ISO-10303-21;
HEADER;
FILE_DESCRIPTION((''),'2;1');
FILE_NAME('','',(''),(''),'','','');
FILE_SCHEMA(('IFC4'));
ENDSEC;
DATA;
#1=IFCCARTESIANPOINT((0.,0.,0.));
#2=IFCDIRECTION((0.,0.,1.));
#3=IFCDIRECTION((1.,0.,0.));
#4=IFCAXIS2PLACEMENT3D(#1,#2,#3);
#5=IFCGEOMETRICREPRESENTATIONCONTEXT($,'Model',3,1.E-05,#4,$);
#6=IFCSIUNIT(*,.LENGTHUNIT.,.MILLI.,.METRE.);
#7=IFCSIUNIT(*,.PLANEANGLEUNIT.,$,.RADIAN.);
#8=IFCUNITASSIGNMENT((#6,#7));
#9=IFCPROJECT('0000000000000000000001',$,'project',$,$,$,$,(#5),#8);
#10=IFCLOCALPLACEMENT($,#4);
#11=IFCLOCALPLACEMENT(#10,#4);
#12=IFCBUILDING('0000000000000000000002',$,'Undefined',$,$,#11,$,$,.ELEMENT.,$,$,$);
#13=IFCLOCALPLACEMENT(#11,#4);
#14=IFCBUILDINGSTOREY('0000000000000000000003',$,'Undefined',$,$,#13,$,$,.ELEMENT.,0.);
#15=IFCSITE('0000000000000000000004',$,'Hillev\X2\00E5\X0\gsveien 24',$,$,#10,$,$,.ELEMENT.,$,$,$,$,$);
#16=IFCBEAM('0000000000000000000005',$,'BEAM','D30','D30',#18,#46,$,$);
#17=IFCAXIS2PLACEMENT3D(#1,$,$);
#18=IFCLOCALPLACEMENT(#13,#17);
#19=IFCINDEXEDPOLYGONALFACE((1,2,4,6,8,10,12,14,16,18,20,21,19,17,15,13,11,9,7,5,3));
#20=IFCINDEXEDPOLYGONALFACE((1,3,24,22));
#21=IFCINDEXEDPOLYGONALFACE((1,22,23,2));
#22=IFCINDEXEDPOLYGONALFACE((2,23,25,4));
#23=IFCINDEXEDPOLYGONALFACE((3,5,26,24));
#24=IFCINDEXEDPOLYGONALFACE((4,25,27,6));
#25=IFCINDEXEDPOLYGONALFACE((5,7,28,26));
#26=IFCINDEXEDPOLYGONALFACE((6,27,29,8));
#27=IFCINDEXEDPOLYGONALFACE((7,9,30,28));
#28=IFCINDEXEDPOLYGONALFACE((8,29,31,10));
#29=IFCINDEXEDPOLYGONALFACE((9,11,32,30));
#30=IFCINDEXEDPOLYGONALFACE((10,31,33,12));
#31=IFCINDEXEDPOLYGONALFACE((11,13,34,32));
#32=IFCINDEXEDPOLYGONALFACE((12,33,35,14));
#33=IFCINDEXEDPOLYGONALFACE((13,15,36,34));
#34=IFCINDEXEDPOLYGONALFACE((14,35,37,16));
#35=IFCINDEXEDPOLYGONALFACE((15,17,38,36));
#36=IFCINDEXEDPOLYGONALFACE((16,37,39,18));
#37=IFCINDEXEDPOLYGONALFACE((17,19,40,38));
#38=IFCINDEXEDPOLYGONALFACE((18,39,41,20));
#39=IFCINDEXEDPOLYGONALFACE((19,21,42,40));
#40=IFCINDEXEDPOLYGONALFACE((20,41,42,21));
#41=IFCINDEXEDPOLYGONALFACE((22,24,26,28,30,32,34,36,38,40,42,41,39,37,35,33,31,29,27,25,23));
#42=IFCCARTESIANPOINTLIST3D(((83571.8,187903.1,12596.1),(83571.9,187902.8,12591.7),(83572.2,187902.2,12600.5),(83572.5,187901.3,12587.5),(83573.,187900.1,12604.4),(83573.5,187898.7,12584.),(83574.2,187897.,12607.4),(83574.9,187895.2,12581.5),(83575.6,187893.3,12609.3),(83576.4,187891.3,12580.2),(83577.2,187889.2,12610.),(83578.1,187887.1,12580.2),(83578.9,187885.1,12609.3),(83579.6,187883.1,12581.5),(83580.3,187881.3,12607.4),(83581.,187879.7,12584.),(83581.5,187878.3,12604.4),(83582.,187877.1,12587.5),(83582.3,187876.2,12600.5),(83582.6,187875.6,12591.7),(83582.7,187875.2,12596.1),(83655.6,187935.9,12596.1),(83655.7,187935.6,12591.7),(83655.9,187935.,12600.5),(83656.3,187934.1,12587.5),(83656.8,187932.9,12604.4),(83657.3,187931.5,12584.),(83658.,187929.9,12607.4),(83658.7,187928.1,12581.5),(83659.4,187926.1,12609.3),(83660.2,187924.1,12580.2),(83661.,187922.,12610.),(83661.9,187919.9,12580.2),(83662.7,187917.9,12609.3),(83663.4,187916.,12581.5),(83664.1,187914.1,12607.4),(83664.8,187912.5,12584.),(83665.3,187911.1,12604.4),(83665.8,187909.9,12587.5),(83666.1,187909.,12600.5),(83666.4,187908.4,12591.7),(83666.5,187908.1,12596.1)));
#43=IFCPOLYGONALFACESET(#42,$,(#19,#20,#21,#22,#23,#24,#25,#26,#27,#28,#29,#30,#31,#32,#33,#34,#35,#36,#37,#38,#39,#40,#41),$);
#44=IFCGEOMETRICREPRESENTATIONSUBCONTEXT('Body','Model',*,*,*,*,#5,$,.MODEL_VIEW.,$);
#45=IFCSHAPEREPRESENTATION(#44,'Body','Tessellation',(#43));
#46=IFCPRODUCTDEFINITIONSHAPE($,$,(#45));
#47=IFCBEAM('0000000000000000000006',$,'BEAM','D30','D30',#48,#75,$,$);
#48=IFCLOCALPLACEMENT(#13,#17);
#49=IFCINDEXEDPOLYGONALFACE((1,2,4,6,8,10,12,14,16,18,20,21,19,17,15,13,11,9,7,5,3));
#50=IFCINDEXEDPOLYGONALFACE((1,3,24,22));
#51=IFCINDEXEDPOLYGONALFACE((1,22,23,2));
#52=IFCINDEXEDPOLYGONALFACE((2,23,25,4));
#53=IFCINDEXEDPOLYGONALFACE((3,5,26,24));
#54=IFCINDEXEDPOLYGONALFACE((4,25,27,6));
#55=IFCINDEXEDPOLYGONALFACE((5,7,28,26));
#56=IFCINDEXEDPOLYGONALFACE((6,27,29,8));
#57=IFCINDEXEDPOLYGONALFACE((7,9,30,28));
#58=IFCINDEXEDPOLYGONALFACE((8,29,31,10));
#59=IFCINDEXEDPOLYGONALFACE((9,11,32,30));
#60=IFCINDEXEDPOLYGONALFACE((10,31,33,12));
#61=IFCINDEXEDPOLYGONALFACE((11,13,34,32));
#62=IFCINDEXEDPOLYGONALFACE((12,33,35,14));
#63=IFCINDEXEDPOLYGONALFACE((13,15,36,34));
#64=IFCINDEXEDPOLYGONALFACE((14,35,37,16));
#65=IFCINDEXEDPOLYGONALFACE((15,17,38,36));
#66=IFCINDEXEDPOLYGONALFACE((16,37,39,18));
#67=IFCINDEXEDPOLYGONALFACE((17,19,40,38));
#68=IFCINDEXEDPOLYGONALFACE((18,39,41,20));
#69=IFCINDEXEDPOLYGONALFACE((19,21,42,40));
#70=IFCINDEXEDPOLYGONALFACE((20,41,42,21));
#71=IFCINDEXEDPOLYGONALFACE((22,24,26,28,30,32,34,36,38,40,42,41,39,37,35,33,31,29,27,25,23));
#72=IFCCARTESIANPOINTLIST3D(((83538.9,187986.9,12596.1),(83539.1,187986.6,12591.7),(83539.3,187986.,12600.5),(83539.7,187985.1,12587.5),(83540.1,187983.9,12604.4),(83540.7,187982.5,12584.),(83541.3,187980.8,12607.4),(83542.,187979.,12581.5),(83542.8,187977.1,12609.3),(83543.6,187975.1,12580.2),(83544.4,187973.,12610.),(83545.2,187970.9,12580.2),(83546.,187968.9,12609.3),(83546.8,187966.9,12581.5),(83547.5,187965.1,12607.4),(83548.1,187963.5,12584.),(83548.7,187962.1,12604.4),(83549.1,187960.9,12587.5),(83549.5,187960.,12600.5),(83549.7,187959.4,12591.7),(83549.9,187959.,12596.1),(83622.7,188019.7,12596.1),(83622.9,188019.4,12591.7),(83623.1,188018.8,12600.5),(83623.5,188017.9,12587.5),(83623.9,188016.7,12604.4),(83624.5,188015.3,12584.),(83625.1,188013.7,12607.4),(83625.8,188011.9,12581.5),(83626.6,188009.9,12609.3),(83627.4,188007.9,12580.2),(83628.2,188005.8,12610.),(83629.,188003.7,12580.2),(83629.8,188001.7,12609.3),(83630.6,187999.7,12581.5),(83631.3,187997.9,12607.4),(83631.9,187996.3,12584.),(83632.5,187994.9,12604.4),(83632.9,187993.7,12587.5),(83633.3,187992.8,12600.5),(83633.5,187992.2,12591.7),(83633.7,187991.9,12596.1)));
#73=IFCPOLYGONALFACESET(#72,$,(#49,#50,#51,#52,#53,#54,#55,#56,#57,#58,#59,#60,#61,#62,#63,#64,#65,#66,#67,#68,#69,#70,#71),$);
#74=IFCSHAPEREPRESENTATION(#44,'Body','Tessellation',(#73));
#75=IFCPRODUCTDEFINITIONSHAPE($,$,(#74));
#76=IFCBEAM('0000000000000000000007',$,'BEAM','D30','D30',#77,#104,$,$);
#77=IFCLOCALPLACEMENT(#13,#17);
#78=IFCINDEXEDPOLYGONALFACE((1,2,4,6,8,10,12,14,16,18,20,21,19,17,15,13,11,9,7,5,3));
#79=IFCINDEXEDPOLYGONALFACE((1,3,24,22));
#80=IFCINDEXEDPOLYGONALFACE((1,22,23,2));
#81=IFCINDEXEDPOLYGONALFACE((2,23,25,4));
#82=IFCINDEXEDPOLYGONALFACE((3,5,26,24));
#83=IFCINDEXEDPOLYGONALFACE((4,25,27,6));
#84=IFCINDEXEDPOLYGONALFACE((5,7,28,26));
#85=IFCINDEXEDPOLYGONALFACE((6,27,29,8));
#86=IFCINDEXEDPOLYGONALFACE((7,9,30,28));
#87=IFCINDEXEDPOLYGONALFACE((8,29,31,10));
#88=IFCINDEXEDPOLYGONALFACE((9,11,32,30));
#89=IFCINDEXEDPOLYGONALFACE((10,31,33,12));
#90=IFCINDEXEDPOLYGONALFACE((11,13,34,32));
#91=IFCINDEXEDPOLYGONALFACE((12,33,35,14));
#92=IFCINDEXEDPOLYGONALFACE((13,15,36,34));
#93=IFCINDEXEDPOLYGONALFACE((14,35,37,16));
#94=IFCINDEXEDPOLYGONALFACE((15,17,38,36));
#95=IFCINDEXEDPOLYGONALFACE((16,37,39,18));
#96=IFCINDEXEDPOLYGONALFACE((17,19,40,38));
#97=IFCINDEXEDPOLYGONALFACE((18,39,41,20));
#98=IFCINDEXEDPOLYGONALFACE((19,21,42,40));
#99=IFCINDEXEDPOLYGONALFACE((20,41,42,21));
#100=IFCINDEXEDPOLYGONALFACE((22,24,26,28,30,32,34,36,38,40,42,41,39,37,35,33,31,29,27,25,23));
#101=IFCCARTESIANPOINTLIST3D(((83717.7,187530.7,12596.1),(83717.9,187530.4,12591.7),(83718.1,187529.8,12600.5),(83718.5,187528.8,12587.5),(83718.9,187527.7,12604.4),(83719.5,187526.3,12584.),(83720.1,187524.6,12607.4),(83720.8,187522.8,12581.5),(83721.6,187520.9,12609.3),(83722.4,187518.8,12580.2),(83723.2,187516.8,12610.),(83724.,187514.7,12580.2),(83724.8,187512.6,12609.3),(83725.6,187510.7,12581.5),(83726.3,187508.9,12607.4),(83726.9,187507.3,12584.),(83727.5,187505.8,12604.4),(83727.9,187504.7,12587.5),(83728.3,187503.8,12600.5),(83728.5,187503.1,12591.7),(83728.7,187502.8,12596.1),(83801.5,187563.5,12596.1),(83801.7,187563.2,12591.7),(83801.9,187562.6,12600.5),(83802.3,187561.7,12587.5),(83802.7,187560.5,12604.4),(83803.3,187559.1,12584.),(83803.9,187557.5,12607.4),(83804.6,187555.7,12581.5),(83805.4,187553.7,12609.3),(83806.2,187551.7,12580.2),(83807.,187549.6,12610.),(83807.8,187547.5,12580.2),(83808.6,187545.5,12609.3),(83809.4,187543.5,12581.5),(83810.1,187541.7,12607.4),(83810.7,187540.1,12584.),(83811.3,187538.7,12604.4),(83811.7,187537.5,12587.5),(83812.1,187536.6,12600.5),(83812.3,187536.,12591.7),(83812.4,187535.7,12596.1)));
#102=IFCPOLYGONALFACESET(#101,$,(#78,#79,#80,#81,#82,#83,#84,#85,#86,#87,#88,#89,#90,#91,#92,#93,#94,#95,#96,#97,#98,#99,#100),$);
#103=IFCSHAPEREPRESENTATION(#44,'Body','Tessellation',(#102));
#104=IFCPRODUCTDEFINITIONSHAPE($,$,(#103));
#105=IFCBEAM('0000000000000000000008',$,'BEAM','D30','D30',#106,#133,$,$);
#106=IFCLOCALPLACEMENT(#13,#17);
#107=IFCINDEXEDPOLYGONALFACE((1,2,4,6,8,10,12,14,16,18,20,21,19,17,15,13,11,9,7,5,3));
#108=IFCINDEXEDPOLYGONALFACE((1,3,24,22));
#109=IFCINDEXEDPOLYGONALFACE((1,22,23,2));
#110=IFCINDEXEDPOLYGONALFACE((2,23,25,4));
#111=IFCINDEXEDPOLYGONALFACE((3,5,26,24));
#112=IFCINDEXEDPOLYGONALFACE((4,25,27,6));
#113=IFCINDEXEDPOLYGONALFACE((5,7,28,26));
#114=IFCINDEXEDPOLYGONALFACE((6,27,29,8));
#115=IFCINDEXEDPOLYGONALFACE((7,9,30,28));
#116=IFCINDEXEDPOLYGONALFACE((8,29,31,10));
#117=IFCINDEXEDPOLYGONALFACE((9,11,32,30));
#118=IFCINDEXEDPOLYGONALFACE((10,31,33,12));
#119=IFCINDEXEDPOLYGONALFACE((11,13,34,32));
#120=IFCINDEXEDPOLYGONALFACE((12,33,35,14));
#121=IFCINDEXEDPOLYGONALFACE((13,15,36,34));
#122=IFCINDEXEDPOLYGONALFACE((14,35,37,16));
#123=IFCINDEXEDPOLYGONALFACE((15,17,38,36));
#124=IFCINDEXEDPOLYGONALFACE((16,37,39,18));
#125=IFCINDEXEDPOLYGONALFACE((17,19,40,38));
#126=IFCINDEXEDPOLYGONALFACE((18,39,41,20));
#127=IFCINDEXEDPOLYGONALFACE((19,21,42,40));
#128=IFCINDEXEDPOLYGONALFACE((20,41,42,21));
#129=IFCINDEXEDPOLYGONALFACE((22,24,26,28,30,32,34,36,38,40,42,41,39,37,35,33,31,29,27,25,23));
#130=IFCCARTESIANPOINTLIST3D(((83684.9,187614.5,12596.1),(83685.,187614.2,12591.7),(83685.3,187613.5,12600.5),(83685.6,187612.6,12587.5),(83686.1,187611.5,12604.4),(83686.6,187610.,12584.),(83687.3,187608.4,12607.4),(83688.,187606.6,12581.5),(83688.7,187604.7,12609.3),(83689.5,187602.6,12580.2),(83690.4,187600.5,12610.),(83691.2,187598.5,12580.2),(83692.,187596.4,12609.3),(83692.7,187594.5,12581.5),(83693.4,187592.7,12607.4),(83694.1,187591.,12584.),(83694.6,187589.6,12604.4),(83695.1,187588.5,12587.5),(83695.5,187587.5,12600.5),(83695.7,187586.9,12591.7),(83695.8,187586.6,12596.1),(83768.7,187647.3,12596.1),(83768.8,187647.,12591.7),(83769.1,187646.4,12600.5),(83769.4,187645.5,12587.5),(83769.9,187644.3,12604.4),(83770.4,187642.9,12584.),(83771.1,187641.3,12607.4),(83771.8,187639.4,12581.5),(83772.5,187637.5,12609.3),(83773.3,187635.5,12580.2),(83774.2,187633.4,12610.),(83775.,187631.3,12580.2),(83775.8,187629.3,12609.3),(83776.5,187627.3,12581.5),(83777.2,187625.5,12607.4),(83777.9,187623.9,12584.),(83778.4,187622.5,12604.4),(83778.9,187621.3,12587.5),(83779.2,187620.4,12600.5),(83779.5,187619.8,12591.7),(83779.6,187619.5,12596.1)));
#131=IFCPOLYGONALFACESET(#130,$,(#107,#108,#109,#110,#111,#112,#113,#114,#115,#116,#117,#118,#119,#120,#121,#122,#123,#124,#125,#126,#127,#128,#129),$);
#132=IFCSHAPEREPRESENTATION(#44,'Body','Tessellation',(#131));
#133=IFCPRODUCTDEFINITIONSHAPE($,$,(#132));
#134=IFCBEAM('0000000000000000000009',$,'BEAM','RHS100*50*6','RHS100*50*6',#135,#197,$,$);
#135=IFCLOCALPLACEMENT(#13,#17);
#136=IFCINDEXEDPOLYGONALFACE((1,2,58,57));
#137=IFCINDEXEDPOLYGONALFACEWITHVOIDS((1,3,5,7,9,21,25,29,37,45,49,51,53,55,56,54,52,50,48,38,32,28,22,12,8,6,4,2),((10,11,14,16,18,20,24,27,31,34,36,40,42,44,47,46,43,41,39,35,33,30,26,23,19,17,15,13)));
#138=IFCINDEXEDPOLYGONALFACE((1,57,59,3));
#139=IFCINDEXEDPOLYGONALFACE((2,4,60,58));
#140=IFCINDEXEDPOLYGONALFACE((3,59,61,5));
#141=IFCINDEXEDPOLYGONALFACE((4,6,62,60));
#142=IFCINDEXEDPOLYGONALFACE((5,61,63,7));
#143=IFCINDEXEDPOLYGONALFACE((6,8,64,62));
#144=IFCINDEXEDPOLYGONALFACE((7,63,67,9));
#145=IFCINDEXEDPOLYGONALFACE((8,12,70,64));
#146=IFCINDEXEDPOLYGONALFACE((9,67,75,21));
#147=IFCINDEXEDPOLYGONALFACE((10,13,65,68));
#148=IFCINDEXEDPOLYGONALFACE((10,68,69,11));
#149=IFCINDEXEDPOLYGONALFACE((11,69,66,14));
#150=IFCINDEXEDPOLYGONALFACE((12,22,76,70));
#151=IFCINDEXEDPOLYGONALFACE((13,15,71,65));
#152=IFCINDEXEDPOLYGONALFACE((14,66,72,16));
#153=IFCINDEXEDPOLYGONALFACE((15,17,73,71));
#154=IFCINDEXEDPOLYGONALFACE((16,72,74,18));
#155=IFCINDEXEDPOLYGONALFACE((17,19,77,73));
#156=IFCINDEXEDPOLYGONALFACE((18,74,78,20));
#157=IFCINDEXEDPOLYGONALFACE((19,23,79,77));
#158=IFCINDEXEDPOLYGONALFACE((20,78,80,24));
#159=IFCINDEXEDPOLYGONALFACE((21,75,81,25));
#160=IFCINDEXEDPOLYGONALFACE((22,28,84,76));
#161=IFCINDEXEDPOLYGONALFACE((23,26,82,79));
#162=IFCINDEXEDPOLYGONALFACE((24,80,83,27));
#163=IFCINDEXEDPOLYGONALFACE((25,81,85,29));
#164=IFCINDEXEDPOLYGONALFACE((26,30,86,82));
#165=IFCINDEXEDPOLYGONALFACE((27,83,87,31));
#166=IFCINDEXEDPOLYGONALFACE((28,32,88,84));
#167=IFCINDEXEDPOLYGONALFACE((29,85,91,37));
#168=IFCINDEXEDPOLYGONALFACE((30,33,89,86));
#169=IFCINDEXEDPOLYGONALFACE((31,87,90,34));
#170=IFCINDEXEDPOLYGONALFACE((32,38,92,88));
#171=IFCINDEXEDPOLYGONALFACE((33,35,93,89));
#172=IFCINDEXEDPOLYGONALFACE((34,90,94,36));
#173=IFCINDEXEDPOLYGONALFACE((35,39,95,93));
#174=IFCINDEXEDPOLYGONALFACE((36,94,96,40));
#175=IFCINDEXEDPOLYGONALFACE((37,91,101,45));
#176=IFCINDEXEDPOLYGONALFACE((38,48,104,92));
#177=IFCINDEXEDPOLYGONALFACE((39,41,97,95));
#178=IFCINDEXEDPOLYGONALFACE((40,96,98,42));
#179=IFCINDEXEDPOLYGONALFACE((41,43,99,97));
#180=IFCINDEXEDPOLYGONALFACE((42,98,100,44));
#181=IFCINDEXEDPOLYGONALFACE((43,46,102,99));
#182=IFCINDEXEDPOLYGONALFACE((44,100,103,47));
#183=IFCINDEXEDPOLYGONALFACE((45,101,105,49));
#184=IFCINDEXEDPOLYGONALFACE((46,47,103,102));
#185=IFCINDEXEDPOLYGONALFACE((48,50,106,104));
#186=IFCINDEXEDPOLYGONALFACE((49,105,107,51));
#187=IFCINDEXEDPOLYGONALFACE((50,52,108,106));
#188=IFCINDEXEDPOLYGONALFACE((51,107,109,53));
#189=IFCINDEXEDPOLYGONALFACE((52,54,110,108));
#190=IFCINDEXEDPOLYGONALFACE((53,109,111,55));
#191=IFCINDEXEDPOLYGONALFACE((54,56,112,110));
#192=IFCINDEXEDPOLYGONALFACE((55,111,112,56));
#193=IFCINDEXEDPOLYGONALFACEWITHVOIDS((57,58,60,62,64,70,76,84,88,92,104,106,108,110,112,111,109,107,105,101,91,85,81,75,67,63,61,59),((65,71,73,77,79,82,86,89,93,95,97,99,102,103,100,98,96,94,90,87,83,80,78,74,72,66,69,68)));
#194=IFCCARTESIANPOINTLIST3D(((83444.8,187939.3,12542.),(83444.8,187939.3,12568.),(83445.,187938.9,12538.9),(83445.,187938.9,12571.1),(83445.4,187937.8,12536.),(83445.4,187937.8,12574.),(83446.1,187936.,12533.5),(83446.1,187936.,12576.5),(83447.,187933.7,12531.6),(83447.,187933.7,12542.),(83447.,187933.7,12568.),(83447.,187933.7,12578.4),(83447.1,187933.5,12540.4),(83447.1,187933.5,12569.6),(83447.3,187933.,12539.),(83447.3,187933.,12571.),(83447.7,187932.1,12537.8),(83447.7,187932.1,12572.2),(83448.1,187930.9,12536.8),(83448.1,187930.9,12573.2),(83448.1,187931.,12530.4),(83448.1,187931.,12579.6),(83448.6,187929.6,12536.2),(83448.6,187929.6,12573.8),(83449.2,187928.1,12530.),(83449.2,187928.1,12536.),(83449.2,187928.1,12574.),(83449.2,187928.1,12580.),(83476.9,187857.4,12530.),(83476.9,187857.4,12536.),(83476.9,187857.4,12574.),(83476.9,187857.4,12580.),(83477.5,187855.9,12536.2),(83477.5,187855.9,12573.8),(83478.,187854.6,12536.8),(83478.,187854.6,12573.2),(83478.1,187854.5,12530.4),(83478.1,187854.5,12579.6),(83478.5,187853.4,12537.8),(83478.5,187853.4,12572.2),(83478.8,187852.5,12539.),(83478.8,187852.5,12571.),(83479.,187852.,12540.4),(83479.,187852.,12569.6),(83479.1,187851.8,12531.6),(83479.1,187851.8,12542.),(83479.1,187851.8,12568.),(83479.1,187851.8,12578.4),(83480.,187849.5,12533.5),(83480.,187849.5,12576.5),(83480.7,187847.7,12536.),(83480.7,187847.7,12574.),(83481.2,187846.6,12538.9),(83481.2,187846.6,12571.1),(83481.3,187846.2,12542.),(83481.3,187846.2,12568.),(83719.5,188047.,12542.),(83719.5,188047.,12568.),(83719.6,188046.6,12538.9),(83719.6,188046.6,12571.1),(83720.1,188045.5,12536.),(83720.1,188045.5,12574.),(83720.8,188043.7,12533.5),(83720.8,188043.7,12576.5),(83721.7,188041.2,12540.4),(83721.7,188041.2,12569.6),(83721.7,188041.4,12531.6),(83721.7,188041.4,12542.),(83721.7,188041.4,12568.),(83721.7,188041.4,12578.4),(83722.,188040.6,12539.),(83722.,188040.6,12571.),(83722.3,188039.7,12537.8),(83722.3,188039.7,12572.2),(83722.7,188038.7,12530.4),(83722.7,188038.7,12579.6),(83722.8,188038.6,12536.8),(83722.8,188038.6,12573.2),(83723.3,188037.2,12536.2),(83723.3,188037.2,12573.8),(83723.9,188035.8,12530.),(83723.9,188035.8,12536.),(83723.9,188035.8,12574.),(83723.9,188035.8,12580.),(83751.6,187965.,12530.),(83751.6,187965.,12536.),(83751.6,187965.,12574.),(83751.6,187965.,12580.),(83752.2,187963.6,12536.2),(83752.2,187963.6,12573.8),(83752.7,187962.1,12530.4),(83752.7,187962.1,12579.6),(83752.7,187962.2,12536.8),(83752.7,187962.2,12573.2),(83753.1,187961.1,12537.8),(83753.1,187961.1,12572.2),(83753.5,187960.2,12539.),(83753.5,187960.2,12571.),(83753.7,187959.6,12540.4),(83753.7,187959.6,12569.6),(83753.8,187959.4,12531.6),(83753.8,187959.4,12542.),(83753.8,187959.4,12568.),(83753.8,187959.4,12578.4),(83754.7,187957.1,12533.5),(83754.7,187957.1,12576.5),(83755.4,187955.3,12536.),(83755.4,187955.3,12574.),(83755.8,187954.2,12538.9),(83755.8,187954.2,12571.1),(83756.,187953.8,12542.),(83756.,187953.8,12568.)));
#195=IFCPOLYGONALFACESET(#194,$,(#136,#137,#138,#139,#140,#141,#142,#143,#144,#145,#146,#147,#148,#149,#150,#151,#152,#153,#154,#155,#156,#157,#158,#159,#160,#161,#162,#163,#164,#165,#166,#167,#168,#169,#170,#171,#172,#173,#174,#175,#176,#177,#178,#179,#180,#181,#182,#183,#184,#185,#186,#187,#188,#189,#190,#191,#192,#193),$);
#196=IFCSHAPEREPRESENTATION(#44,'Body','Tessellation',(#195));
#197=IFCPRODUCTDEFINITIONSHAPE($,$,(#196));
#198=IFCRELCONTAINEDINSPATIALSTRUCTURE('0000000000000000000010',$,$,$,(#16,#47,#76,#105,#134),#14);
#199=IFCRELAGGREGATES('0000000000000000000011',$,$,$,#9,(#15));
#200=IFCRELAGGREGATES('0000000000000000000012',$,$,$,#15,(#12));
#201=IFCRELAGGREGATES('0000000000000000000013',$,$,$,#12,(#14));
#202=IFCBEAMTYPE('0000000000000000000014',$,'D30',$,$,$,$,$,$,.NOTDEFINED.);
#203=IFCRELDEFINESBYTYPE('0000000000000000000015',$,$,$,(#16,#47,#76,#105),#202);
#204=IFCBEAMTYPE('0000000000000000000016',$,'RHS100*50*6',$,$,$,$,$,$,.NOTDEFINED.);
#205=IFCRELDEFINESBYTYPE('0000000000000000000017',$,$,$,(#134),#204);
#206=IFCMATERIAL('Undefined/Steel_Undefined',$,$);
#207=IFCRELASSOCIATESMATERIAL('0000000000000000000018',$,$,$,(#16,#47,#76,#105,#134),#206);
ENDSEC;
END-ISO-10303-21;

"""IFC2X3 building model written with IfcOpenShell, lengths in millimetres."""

from ifc_helpers import new_model, si_unit, frame, frame_2d, origin_with_axes, place, context, subcontext, project, spatial, hollow_rectangle, circle, extrude, material, type_object, element, save


model = new_model("IFC2X3")

# Units and contexts
model_context = context("Model", 3, precision=1e-05, world=origin_with_axes())
body_context = subcontext(model_context, "Body", "Model", "MODEL_VIEW")
ifc_project = project(units=[si_unit("LENGTHUNIT", "METRE", prefix="MILLI"), si_unit("PLANEANGLEUNIT", "RADIAN")], contexts=[model_context])

# Site, building, storey
site_placement = place(None, origin_with_axes())
site = spatial("IfcSite", under=ifc_project, at=site_placement, Name="Hillevågsveien 24", CompositionType="ELEMENT")
building_placement = place(site_placement, origin_with_axes())
building = spatial("IfcBuilding", under=site, at=building_placement, Name="Undefined", CompositionType="ELEMENT")
storey_placement = place(building_placement, origin_with_axes())
storey = spatial("IfcBuildingStorey", under=building, at=storey_placement, Name="Undefined", CompositionType="ELEMENT", Elevation=0.0)

# Beams
ifc_material_1 = material(Name="Undefined/Steel_Undefined")
beam_type_1 = type_object("IfcBeamType", Name="D30", PredefinedType="NOTDEFINED")
for number, where, z_axis, x_axis, name in (
    (1, (83661.0, 187922.0, 12595.0), (0.364877, -0.931056, 0.0), (-0.931056, -0.364877, 0.0), "BEAM"),
    (2, (83628.2, 188005.8, 12595.0), (0.364877, -0.931056, 0.0), (-0.931056, -0.364877, 0.0), "BEAM"),
    (3, (83807.0, 187549.6, 12595.0), (0.364877, -0.931056, 0.0), (-0.931056, -0.364877, 0.0), "BEAM"),
    (4, (83774.2, 187633.4, 12595.0), (0.364877, -0.931056, 0.0), (-0.931056, -0.364877, 0.0), "BEAM"),
):
    element("IfcBeam", number, at=place(storey_placement, frame(where, z_axis=z_axis, x_axis=x_axis)), inside=storey, type_object=beam_type_1, material=ifc_material_1, Name=name, Description="D30", ObjectType="D30", context=body_context, shape_type="SweptSolid", body=[
        extrude(circle(Radius=15.0, at=frame_2d((0.0, 0.0), x_axis=(1.0, 0.0))), frame((90.0, 0.0, 0.0), z_axis=(-1.0, 0.0, 0.0), x_axis=(0.0, -1.0, 0.0)), (0.0, 0.0, 1.0), 90.0),
    ])
beam_type_2 = type_object("IfcBeamType", Name="RHS100*50*6", PredefinedType="NOTDEFINED")
for number, where, z_axis, x_axis, name in (
    (5, (83737.7, 188000.4, 12555.0), (0.364877, -0.931056, 0.0), (-0.931056, -0.364877, 0.0), "BEAM"),
):
    element("IfcBeam", number, at=place(storey_placement, frame(where, z_axis=z_axis, x_axis=x_axis)), inside=storey, type_object=beam_type_2, material=ifc_material_1, Name=name, Description="RHS100*50*6", ObjectType="RHS100*50*6", context=body_context, shape_type="SweptSolid", body=[
        extrude(hollow_rectangle(XDim=50.0, YDim=100.0, WallThickness=6.0, InnerFilletRadius=6.0, OuterFilletRadius=12.0, at=frame_2d((0.0, 0.0), x_axis=(1.0, 0.0))), frame((295.0, 0.0, 0.0), z_axis=(-1.0, 0.0, 0.0), x_axis=(0.0, -1.0, 0.0)), (0.0, 0.0, 1.0), 295.0),
    ])

save(model, "model.ifc")
